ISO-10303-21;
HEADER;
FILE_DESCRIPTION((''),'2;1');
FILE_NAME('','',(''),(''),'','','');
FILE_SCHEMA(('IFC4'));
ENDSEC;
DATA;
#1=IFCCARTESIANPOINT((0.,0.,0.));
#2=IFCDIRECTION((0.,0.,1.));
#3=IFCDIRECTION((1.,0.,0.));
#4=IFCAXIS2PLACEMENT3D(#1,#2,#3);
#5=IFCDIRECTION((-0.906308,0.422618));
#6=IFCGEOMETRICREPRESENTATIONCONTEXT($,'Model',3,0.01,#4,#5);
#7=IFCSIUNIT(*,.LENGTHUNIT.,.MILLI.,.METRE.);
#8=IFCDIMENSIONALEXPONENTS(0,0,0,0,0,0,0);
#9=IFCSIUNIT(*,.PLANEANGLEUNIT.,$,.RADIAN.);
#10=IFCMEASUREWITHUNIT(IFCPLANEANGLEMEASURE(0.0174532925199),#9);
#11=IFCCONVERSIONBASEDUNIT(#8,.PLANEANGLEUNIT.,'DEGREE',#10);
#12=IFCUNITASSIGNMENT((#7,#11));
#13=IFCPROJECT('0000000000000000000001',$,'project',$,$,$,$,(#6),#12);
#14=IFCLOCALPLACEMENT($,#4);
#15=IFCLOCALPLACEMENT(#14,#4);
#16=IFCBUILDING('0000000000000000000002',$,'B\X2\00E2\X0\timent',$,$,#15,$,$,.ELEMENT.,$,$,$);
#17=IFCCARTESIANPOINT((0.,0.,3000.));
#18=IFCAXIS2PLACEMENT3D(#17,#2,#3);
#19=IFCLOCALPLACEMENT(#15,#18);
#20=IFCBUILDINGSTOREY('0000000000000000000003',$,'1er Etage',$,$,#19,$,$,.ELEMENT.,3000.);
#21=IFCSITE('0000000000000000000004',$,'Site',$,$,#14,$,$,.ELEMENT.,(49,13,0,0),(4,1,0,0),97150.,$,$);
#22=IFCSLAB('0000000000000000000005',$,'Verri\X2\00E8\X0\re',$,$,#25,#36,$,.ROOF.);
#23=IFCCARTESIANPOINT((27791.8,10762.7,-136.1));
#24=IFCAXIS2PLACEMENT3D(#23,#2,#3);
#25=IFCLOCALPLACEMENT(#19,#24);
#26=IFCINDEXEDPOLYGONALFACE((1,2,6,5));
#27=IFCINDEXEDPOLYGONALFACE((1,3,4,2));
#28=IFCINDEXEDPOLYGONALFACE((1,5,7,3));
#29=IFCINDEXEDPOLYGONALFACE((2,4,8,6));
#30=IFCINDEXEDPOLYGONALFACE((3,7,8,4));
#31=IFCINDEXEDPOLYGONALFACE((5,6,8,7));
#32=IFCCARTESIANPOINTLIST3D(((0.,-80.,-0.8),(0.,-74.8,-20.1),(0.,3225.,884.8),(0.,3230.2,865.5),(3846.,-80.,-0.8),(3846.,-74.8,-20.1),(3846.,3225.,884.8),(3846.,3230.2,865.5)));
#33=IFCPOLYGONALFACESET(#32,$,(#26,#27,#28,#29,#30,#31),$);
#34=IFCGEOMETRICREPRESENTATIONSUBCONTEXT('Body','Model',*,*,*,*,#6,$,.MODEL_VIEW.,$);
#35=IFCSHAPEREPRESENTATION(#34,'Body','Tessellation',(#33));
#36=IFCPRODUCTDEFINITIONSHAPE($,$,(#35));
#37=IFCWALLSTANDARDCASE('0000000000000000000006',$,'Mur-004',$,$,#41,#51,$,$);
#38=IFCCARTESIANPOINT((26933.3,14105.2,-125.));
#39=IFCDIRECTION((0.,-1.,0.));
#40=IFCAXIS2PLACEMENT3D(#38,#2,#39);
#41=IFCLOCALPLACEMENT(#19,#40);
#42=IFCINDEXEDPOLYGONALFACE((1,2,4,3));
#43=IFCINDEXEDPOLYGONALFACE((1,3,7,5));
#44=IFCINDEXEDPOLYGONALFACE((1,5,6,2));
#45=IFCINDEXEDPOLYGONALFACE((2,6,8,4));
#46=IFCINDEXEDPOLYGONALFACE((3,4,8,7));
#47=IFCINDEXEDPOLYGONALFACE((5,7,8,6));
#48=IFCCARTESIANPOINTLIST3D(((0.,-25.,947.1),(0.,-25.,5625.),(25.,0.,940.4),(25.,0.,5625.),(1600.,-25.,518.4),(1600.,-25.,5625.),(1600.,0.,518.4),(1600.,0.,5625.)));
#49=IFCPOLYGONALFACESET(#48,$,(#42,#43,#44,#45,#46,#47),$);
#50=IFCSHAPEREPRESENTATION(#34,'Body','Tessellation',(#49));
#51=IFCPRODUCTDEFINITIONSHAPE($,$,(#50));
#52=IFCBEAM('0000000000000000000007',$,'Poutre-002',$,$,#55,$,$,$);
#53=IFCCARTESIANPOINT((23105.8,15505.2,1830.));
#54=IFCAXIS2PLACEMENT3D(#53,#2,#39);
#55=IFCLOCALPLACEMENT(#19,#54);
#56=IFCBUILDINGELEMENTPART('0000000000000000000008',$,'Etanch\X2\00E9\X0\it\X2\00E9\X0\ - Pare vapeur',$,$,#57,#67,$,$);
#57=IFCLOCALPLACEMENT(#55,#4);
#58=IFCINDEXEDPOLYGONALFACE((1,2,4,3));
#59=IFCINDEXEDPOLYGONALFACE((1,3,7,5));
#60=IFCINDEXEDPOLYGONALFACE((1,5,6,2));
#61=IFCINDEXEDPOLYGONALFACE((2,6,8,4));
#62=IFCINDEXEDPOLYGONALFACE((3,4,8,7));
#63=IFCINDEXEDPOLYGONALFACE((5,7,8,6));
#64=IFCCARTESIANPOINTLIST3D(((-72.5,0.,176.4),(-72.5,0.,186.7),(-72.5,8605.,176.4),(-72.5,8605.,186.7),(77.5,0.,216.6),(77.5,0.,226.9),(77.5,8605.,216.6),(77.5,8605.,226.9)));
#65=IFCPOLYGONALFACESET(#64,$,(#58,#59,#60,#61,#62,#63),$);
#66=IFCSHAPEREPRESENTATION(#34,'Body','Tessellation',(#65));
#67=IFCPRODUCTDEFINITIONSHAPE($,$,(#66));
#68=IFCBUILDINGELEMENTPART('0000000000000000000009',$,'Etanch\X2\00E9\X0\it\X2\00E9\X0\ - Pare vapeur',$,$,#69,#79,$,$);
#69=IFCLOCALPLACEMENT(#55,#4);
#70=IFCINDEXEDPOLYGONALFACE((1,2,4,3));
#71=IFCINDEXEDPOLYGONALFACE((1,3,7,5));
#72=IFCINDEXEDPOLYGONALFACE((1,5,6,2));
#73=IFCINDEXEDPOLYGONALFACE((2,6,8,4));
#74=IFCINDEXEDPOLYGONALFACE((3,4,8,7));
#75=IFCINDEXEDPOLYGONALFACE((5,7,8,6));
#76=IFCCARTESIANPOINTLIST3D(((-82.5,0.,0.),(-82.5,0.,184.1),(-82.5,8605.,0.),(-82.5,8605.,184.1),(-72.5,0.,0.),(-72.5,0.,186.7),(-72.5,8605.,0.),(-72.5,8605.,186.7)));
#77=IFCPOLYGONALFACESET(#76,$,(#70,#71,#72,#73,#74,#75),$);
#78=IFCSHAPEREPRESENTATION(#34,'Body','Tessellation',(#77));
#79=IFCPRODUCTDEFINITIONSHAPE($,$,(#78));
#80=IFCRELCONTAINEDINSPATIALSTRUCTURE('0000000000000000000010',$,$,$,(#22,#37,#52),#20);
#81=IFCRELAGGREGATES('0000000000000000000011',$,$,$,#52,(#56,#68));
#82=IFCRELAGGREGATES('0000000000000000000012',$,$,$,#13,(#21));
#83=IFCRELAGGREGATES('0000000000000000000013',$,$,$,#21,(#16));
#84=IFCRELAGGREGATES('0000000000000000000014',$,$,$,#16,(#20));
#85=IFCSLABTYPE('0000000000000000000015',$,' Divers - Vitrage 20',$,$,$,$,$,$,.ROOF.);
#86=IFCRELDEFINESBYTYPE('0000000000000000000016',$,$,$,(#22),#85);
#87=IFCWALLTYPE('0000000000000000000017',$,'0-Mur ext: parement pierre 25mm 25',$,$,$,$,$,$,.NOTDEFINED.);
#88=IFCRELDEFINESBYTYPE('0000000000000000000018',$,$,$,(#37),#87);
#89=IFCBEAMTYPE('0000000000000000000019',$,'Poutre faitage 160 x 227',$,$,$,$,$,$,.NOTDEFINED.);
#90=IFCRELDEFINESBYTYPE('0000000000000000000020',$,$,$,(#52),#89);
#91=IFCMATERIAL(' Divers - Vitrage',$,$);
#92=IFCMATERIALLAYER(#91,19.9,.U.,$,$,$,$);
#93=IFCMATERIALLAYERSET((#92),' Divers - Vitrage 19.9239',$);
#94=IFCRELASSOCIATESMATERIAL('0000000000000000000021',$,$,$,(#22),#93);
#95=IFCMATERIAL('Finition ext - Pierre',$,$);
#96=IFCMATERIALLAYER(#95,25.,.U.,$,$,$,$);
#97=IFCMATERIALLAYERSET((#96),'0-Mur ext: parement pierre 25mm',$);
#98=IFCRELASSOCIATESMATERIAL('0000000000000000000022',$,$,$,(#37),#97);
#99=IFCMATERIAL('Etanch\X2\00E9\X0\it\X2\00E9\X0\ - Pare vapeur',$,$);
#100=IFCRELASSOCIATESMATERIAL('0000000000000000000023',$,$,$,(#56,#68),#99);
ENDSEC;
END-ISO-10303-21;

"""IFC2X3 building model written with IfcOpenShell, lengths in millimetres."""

from ifc_helpers import new_model, entity, si_unit, converted_unit, direction, frame, origin_with_axes, place, context, subcontext, project, spatial, polyline, outline, extrude, clip, halfspace, material, layer, layer_set, layer_usage, type_object, element, aggregate, save


model = new_model("IFC2X3")

# Units and contexts
model_context = context("Model", 3, precision=0.01, world=origin_with_axes(), true_north=direction((-0.906308, 0.422618)))
body_context = subcontext(model_context, "Body", "Model", "MODEL_VIEW")
ifc_project = project(units=[si_unit("LENGTHUNIT", "METRE", prefix="MILLI"), converted_unit("PLANEANGLEUNIT", "DEGREE", entity("IfcPlaneAngleMeasure", 0.0174532925199), si_unit("PLANEANGLEUNIT", "RADIAN"), dimensions=[0, 0, 0, 0, 0, 0, 0])], contexts=[model_context])

# Site, building, storey
site_placement = place(None, origin_with_axes())
site = spatial("IfcSite", under=ifc_project, at=site_placement, Name="Site", CompositionType="ELEMENT", RefLatitude=(49, 13, 0, 0), RefLongitude=(4, 1, 0, 0), RefElevation=97150.0)
building_placement = place(site_placement, origin_with_axes())
building = spatial("IfcBuilding", under=site, at=building_placement, Name="Bâtiment", CompositionType="ELEMENT")
storey_placement = place(building_placement, frame((0.0, 0.0, 3000.0), z_axis=(0.0, 0.0, 1.0), x_axis=(1.0, 0.0, 0.0)))
storey = spatial("IfcBuildingStorey", under=building, at=storey_placement, Name="1er Etage", CompositionType="ELEMENT", Elevation=3000.0)

# Slab
ifc_material_1 = material(Name=" Divers - Vitrage")
ifc_layer_1 = layer(ifc_material_1, 19.9, ventilated="UNKNOWN")
ifc_layer_set_1 = layer_set([ifc_layer_1], Name=" Divers - Vitrage 19.9239")
ifc_layer_usage_1 = layer_usage(ifc_layer_set_1, "AXIS3", "NEGATIVE", 19.9)
slab_type_1 = type_object("IfcSlabType", Name=" Divers - Vitrage 20", PredefinedType="ROOF")
slab_1_placement = place(storey_placement, frame((27791.8, 10762.7, -136.1), z_axis=(0.0, 0.0, 1.0), x_axis=(1.0, 0.0, 0.0)))
element("IfcSlab", 1, at=slab_1_placement, inside=storey, type_object=slab_type_1, material=ifc_layer_usage_1, Name="Verrière", PredefinedType="ROOF", context=body_context, shape_type="SweptSolid", body=[
    extrude(outline(polyline([(0.0, -77.5), (3846.0, -77.5), (3846.0, 3344.1), (0.0, 3344.1), (0.0, -77.5)])), frame((0.0, 0.0, 0.0), z_axis=(0.0, -0.258819, 0.965926), x_axis=(1.0, 0.0, 0.0)), (0.0, 0.0, 1.0), 19.9),
])
ifc_material_2 = material(Name="Etanchéité - Pare vapeur")

# Wall
ifc_material_3 = material(Name="Finition ext - Pierre")
ifc_layer_2 = layer(ifc_material_3, 25.0, ventilated="UNKNOWN")
ifc_layer_set_2 = layer_set([ifc_layer_2], Name="0-Mur ext: parement pierre 25mm")
ifc_layer_usage_2 = layer_usage(ifc_layer_set_2, "AXIS2", "POSITIVE", -25.0)
wall_type_1 = type_object("IfcWallType", Name="0-Mur ext: parement pierre 25mm 25", PredefinedType="NOTDEFINED")
wall_1_placement = place(storey_placement, frame((26933.3, 14105.2, -125.0), z_axis=(0.0, 0.0, 1.0), x_axis=(0.0, -1.0, 0.0)))
element("IfcWallStandardCase", 2, at=wall_1_placement, inside=storey, type_object=wall_type_1, material=ifc_layer_usage_2, Name="Mur-004", context=body_context, shape_type="Clipping", body=[
    clip(extrude(outline(polyline([(0.0, -25.0), (1600.0, -25.0), (1600.0, 0.0), (25.0, 0.0), (0.0, -25.0)])), origin_with_axes(), (0.0, 0.0, 1.0), 5625.0), halfspace(frame((236.8, 0.0, 883.6), z_axis=(0.258819, 0.0, 0.965926), x_axis=(0.0, -1.0, 0.0)), True)),
])

# Beam, building element parts
beam_type_1 = type_object("IfcBeamType", Name="Poutre faitage 160 x 227", PredefinedType="NOTDEFINED")
beam_1_placement = place(storey_placement, frame((23105.8, 15505.2, 1830.0), z_axis=(0.0, 0.0, 1.0), x_axis=(0.0, -1.0, 0.0)))
beam_1 = element("IfcBeam", 3, at=beam_1_placement, inside=storey, type_object=beam_type_1, Name="Poutre-002")
building_element_part_1_placement = place(beam_1_placement, origin_with_axes())
building_element_part_1 = element("IfcBuildingElementPart", 4, at=building_element_part_1_placement, material=ifc_material_2, Name="Etanchéité - Pare vapeur", context=body_context, shape_type="SweptSolid", body=[
    extrude(outline(polyline([(-72.5, 186.7), (-72.5, 176.4), (77.5, 216.6), (77.5, 226.9), (-72.5, 186.7)])), frame((0.0, 8605.0, 0.0), z_axis=(0.0, -1.0, 0.0), x_axis=(1.0, 0.0, 0.0)), (0.0, 0.0, 1.0), 8605.0),
])
building_element_part_2_placement = place(beam_1_placement, origin_with_axes())
building_element_part_2 = element("IfcBuildingElementPart", 5, at=building_element_part_2_placement, material=ifc_material_2, Name="Etanchéité - Pare vapeur", context=body_context, shape_type="SweptSolid", body=[
    extrude(outline(polyline([(-72.5, 186.7), (-82.5, 184.1), (-82.5, 0.0), (-72.5, 0.0), (-72.5, 186.7)])), frame((0.0, 8605.0, 0.0), z_axis=(0.0, -1.0, 0.0), x_axis=(1.0, 0.0, 0.0)), (0.0, 0.0, 1.0), 8605.0),
])
aggregate(beam_1, [building_element_part_1, building_element_part_2])

save(model, "model.ifc")
